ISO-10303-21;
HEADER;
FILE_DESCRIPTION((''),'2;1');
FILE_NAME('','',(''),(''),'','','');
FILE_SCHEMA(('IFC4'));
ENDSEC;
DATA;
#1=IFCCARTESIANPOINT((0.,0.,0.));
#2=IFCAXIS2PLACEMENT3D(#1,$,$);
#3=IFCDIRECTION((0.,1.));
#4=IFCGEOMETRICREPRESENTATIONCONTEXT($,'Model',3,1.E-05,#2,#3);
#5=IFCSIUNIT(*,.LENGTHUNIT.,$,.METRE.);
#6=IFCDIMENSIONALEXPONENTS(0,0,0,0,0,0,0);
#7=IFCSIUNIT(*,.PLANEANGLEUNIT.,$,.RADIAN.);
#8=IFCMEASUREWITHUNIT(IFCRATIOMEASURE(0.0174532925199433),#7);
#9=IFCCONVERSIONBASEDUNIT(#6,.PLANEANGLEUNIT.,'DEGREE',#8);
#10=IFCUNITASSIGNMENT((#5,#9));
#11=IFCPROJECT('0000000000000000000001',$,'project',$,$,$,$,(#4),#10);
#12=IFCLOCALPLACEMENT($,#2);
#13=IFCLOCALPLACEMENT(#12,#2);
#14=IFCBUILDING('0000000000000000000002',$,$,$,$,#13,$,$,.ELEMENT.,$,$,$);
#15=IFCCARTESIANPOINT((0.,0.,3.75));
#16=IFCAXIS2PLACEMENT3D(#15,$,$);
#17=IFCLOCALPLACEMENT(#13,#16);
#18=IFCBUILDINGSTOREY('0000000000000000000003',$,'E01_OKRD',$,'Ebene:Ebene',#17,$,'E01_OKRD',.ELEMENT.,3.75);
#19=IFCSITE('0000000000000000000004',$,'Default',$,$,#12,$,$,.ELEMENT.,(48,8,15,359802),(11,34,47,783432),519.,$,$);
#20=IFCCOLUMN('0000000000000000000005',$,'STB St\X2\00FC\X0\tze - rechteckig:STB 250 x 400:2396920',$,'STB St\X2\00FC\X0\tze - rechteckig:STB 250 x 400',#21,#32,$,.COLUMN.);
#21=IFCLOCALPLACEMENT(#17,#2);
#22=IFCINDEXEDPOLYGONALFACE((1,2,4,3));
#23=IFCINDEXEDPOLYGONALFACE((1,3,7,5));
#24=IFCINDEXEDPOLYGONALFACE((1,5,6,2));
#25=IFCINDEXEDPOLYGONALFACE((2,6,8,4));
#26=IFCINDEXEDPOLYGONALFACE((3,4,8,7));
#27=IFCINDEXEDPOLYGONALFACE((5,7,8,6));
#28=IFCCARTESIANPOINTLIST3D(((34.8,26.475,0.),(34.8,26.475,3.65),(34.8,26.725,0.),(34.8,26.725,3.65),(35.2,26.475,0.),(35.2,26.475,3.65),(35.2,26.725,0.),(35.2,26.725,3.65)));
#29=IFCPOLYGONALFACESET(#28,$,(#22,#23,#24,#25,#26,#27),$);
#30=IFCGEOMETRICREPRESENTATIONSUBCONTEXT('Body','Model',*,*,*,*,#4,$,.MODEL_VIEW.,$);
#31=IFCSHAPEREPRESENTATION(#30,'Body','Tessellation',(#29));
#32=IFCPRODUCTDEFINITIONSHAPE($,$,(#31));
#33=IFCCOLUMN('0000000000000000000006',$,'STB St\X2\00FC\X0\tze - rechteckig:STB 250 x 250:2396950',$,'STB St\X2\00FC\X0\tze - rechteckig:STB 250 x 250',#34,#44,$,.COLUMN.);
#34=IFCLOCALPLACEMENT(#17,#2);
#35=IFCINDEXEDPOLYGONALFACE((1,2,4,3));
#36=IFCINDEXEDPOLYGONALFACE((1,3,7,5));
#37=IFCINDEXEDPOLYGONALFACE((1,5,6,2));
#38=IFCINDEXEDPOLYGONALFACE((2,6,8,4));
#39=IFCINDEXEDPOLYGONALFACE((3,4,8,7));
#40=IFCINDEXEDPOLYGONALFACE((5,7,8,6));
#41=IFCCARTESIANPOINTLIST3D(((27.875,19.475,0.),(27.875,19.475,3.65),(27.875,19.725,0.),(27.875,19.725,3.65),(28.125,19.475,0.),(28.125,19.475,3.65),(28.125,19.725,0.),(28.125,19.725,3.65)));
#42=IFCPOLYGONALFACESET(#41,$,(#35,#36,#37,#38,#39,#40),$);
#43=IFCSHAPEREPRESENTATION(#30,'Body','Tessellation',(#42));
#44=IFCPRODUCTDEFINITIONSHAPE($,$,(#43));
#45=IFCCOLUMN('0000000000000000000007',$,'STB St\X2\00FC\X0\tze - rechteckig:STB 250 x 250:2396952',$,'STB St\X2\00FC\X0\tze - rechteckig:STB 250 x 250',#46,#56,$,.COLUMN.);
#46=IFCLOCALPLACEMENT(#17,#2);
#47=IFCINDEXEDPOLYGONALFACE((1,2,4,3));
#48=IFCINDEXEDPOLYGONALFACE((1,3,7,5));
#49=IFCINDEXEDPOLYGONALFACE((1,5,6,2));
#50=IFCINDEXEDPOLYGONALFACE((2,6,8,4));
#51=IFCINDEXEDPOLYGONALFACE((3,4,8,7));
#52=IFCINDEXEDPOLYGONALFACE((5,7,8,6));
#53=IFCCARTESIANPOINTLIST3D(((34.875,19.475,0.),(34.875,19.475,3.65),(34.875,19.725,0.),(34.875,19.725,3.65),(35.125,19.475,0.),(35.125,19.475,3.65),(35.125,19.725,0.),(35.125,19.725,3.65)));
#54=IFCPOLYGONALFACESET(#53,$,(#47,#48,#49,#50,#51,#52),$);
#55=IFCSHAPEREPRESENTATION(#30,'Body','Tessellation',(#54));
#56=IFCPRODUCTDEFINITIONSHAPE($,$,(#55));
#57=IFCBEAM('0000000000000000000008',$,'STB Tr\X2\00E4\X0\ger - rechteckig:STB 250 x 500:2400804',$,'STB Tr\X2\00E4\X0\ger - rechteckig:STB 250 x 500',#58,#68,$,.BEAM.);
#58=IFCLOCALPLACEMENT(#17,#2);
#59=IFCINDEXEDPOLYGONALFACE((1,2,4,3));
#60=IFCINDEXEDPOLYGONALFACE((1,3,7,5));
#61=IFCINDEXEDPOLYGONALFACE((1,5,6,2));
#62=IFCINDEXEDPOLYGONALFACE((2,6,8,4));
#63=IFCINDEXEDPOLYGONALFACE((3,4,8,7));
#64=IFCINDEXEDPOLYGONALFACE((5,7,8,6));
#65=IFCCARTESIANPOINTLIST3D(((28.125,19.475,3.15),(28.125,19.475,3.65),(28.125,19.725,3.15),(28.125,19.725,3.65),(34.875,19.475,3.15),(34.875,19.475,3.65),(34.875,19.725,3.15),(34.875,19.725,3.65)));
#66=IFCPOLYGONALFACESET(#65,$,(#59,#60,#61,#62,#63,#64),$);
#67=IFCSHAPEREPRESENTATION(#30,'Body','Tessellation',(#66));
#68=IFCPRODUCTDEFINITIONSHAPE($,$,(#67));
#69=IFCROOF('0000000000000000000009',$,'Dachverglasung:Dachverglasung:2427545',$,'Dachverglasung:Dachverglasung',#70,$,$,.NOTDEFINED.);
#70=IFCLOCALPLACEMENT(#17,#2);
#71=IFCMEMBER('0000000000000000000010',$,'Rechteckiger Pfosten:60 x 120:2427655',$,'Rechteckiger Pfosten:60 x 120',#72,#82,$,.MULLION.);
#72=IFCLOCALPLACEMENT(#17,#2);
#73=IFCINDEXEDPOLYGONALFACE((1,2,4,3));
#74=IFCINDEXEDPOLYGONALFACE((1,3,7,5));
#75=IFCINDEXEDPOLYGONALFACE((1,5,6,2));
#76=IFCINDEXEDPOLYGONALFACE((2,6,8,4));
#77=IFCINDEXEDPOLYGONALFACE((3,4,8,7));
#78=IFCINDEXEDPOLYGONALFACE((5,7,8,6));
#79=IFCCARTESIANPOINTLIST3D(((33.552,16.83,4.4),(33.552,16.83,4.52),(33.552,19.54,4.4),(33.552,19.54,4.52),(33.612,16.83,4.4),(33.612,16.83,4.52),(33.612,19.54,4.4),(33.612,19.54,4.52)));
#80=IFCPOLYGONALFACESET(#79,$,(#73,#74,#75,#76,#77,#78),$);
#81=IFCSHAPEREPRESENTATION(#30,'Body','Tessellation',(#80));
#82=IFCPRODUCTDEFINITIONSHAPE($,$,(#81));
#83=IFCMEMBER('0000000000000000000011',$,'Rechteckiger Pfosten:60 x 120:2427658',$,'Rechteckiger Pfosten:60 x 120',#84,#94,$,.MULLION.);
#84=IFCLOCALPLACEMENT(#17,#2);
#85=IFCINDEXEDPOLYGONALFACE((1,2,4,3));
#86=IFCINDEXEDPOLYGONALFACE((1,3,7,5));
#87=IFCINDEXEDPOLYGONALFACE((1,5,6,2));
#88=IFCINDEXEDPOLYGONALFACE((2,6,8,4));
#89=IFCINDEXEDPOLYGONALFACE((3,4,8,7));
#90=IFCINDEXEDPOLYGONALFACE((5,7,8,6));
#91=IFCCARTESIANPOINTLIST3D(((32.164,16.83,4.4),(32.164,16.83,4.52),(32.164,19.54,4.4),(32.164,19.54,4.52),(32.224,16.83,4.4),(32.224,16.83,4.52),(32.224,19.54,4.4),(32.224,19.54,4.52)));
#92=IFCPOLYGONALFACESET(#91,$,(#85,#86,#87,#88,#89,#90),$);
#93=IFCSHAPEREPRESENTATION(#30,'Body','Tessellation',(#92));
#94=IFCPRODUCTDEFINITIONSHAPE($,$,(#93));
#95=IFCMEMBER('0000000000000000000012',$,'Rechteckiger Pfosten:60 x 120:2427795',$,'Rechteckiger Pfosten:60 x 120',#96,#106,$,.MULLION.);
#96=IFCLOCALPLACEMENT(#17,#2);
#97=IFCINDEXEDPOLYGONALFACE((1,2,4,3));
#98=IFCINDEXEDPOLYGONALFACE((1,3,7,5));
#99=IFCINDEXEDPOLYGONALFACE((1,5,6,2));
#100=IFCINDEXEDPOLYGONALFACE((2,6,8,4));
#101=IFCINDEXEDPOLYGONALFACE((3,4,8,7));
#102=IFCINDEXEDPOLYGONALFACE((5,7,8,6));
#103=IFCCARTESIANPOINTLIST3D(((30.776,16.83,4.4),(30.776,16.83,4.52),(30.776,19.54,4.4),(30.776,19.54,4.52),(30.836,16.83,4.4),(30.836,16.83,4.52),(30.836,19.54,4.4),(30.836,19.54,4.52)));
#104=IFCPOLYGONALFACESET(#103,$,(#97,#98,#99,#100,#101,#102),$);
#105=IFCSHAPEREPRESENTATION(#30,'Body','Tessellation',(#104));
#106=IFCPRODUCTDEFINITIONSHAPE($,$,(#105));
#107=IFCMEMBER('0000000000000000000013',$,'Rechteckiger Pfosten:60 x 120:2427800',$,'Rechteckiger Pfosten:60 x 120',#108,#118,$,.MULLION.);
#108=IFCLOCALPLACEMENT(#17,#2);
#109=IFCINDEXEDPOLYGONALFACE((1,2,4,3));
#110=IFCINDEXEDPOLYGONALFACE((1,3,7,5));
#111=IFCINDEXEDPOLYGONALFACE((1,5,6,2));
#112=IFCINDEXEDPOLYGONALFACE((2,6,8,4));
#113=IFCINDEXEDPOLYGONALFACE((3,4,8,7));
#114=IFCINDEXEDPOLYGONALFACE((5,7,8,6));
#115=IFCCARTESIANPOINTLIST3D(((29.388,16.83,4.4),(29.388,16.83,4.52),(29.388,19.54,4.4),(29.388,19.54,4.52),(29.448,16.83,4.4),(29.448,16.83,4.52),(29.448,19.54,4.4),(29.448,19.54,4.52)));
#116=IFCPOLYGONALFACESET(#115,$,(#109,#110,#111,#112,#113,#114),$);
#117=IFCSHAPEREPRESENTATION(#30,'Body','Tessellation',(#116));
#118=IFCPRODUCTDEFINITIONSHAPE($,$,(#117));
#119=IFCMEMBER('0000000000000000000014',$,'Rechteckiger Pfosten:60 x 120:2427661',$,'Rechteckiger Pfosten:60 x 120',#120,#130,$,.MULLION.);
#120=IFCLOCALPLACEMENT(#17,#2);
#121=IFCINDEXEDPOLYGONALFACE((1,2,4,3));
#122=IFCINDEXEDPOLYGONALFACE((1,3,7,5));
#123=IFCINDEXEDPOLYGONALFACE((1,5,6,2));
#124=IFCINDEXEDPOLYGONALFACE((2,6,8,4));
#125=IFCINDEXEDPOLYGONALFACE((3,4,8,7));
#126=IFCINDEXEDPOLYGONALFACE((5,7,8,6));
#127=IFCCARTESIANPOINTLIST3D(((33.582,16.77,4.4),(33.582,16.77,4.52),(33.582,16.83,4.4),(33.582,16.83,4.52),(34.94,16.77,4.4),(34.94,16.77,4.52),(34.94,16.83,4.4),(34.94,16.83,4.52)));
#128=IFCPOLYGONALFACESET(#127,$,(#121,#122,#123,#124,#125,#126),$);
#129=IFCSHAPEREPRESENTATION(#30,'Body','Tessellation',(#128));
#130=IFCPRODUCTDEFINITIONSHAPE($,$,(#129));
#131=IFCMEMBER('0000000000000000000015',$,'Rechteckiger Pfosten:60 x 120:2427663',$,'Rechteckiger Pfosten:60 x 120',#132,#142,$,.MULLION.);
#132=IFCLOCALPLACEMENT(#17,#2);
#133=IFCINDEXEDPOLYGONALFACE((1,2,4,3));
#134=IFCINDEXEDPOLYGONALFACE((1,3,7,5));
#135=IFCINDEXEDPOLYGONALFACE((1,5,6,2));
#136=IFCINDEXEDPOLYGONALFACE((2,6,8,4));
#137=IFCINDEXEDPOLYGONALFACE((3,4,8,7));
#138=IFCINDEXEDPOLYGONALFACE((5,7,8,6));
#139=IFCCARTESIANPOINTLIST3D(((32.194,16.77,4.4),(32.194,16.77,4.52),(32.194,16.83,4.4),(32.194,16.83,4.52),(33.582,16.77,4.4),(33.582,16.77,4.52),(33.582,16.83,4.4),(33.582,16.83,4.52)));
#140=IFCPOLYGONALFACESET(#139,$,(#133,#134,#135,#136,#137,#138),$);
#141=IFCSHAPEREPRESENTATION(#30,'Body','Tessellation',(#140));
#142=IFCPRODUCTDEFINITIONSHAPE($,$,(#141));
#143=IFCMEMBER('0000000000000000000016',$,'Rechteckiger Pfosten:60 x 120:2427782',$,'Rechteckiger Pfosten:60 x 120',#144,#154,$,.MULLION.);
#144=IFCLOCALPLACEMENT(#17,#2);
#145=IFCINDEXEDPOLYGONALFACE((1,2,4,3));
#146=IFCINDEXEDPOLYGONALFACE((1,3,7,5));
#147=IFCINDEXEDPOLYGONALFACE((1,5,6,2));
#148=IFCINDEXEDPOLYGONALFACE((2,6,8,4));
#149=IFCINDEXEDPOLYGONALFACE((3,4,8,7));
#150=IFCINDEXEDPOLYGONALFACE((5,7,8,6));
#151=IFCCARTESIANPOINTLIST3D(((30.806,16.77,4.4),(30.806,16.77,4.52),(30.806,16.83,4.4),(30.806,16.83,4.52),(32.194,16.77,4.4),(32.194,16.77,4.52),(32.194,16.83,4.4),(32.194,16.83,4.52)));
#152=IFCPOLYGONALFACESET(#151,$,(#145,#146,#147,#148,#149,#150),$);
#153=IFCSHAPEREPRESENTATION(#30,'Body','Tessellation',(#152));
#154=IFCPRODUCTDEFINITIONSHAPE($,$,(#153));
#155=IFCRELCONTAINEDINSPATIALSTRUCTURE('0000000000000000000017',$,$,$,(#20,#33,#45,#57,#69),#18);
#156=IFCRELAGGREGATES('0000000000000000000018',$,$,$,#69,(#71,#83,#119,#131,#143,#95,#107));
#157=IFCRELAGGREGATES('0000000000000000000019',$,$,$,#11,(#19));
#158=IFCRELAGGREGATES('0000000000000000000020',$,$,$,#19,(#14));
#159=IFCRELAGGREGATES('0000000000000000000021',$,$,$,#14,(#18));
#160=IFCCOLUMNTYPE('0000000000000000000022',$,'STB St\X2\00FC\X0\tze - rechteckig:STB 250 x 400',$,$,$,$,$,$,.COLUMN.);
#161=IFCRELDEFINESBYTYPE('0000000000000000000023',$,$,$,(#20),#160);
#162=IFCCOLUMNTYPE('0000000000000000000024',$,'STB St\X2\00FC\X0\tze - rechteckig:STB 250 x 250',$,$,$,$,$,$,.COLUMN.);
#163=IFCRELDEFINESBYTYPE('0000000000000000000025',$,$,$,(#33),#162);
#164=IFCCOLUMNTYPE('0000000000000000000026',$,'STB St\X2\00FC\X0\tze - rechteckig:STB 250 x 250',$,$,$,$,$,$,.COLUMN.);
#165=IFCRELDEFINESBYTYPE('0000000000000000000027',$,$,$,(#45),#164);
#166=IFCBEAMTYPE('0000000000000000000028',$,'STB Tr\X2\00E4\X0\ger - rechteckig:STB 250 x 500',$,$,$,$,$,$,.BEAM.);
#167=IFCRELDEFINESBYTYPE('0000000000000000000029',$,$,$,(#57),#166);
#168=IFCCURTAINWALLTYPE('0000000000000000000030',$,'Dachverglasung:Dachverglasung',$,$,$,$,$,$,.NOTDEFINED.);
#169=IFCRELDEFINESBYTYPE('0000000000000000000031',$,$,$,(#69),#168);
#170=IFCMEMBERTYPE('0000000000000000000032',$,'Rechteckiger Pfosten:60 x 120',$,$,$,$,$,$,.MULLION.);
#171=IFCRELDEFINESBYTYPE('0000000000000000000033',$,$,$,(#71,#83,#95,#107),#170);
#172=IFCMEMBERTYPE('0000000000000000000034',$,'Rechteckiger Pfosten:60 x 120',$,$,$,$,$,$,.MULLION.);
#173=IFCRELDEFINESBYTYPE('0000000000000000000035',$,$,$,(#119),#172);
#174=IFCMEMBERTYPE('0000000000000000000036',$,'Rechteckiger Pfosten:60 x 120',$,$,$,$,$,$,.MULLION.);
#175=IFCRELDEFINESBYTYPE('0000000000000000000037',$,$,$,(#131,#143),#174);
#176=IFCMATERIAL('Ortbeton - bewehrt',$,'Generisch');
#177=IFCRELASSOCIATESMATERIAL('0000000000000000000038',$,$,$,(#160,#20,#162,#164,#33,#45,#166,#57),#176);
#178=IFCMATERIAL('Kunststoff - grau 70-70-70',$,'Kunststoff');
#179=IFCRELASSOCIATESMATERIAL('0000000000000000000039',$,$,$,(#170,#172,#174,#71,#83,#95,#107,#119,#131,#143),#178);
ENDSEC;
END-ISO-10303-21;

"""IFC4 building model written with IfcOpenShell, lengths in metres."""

from ifc_helpers import new_model, entity, si_unit, converted_unit, direction, frame, frame_2d, origin, origin_2d_with_axis, place, context, subcontext, project, spatial, rectangle, extrude, source, transform, mapped, material, material_profile, profile_set, profile_usage, type_object, type_shapes, element, aggregate, save


model = new_model("IFC4")

# Units and contexts
model_context = context("Model", 3, precision=1e-05, world=origin(), true_north=direction((0.0, 1.0)))
body_context = subcontext(model_context, "Body", "Model", "MODEL_VIEW")
ifc_project = project(units=[si_unit("LENGTHUNIT", "METRE"), converted_unit("PLANEANGLEUNIT", "DEGREE", entity("IfcRatioMeasure", 0.0174532925199433), si_unit("PLANEANGLEUNIT", "RADIAN"), dimensions=[0, 0, 0, 0, 0, 0, 0])], contexts=[model_context])

# Site, building, storey
site_placement = place(None, frame((0.0, 0.0, 0.0)))
site = spatial("IfcSite", under=ifc_project, at=site_placement, Name="Default", CompositionType="ELEMENT", RefLatitude=(48, 8, 15, 359802), RefLongitude=(11, 34, 47, 783432), RefElevation=519.0)
building_placement = place(site_placement, origin())
building = spatial("IfcBuilding", under=site, at=building_placement, CompositionType="ELEMENT")
storey_placement = place(building_placement, frame((0.0, 0.0, 3.75)))
storey = spatial("IfcBuildingStorey", under=building, at=storey_placement, Name="E01_OKRD", ObjectType="Ebene:Ebene", LongName="E01_OKRD", CompositionType="ELEMENT", Elevation=3.75)

# Columns
ifc_material_1 = material(Name="Ortbeton - bewehrt", Category="Generisch")
ifc_material_profile_1 = material_profile(ifc_material_1, rectangle(XDim=0.4, YDim=0.25, at=frame_2d((0.0, 0.0), x_axis=(1.0, 0.0))), Name="STB 250 x 400")
ifc_profile_set_1 = profile_set([ifc_material_profile_1], Name="STB 250 x 400")
ifc_profile_usage_1 = profile_usage(ifc_profile_set_1)
column_type_1 = type_object("IfcColumnType", Name="STB Stütze - rechteckig:STB 250 x 400", PredefinedType="COLUMN", material=ifc_profile_set_1)
shared_shape_1 = source(origin(), body_context, "Body", "SweptSolid", [
    extrude(rectangle(XDim=0.4, YDim=0.25, at=frame_2d((0.0, 0.0), x_axis=(1.0, 0.0))), frame((0.2, 0.125, 0.0), z_axis=(0.0, 0.0, 1.0), x_axis=(-1.0, 0.0, 0.0)), (0.0, 0.0, 1.0), 3.65),
])
type_shapes(column_type_1, [shared_shape_1])
column_1_placement = place(storey_placement, frame((34.8, 26.475, 0.0)))
element("IfcColumn", 1, at=column_1_placement, inside=storey, type_object=column_type_1, material=ifc_profile_usage_1, Name="STB Stütze - rechteckig:STB 250 x 400:2396920", ObjectType="STB Stütze - rechteckig:STB 250 x 400", PredefinedType="COLUMN", context=body_context, shape_type="MappedRepresentation", body=[
    mapped(shared_shape_1, transform((0.0, 0.0, 0.0), scale=1.0)),
])
ifc_material_profile_2 = material_profile(ifc_material_1, rectangle(XDim=0.25, YDim=0.25, at=origin_2d_with_axis()), Name="STB 250 x 250")
ifc_profile_set_2 = profile_set([ifc_material_profile_2], Name="STB 250 x 250")
ifc_profile_usage_2 = profile_usage(ifc_profile_set_2)
column_type_2 = type_object("IfcColumnType", Name="STB Stütze - rechteckig:STB 250 x 250", PredefinedType="COLUMN", material=ifc_profile_set_2)
shared_shape_2 = source(origin(), body_context, "Body", "SweptSolid", [
    extrude(rectangle(XDim=0.25, YDim=0.25, at=frame_2d((0.0, 0.0), x_axis=(1.0, 0.0))), frame((0.125, 0.125, 0.0), z_axis=(0.0, 0.0, 1.0), x_axis=(-1.0, 0.0, 0.0)), (0.0, 0.0, 1.0), 3.65),
])
type_shapes(column_type_2, [shared_shape_2])
column_2_placement = place(storey_placement, frame((27.875, 19.475, 0.0)))
element("IfcColumn", 2, at=column_2_placement, inside=storey, type_object=column_type_2, material=ifc_profile_usage_2, Name="STB Stütze - rechteckig:STB 250 x 250:2396950", ObjectType="STB Stütze - rechteckig:STB 250 x 250", PredefinedType="COLUMN", context=body_context, shape_type="MappedRepresentation", body=[
    mapped(shared_shape_2, transform((0.0, 0.0, 0.0), scale=1.0)),
])
ifc_profile_usage_3 = profile_usage(ifc_profile_set_2)
column_type_3 = type_object("IfcColumnType", Name="STB Stütze - rechteckig:STB 250 x 250", PredefinedType="COLUMN", material=ifc_profile_set_2)
shared_shape_3 = source(origin(), body_context, "Body", "SweptSolid", [
    extrude(rectangle(XDim=0.25, YDim=0.25, at=frame_2d((0.0, 0.0), x_axis=(1.0, 0.0))), frame((0.125, 0.125, 0.0), z_axis=(0.0, 0.0, 1.0), x_axis=(-1.0, 0.0, 0.0)), (0.0, 0.0, 1.0), 3.65),
])
type_shapes(column_type_3, [shared_shape_3])
column_3_placement = place(storey_placement, frame((34.875, 19.475, 0.0)))
element("IfcColumn", 3, at=column_3_placement, inside=storey, type_object=column_type_3, material=ifc_profile_usage_3, Name="STB Stütze - rechteckig:STB 250 x 250:2396952", ObjectType="STB Stütze - rechteckig:STB 250 x 250", PredefinedType="COLUMN", context=body_context, shape_type="MappedRepresentation", body=[
    mapped(shared_shape_3, transform((0.0, 0.0, 0.0), scale=1.0)),
])

# Beam
ifc_material_profile_3 = material_profile(ifc_material_1, rectangle(XDim=0.5, YDim=0.25, at=frame_2d((0.0, 0.0), x_axis=(1.0, 0.0))), Name="STB 250 x 500")
ifc_profile_set_3 = profile_set([ifc_material_profile_3], Name="STB 250 x 500")
ifc_profile_usage_4 = profile_usage(ifc_profile_set_3, cardinal=8)
beam_type = type_object("IfcBeamType", Name="STB Träger - rechteckig:STB 250 x 500", PredefinedType="BEAM", material=ifc_profile_set_3)
shared_shape_4 = source(origin(), body_context, "Body", "SweptSolid", [
    extrude(rectangle(XDim=0.5, YDim=0.25, at=frame_2d((0.0, 0.0), x_axis=(1.0, 0.0))), frame((0.0, 0.125, 0.25), z_axis=(1.0, 0.0, 0.0), x_axis=(0.0, 0.0, -1.0)), (0.0, 0.0, 1.0), 6.75),
])
type_shapes(beam_type, [shared_shape_4])
beam_placement = place(storey_placement, frame((28.125, 19.475, 3.15)))
element("IfcBeam", 4, at=beam_placement, inside=storey, type_object=beam_type, material=ifc_profile_usage_4, Name="STB Träger - rechteckig:STB 250 x 500:2400804", ObjectType="STB Träger - rechteckig:STB 250 x 500", PredefinedType="BEAM", context=body_context, shape_type="MappedRepresentation", body=[
    mapped(shared_shape_4, transform((0.0, 0.0, 0.0), scale=1.0)),
])

# Roof, members
curtain_wall_type = type_object("IfcCurtainWallType", Name="Dachverglasung:Dachverglasung", PredefinedType="NOTDEFINED")
roof_placement = place(storey_placement, frame((0.0, 0.0, -3.75)))
roof = element("IfcRoof", 5, at=roof_placement, inside=storey, type_object=curtain_wall_type, Name="Dachverglasung:Dachverglasung:2427545", ObjectType="Dachverglasung:Dachverglasung", PredefinedType="NOTDEFINED")
ifc_material_2 = material(Name="Kunststoff - grau 70-70-70", Category="Kunststoff")
ifc_material_profile_4 = material_profile(ifc_material_2, rectangle(XDim=0.06, YDim=0.12, at=frame_2d((0.0, 0.0), x_axis=(1.0, 0.0))), Name="60 x 120")
ifc_profile_set_4 = profile_set([ifc_material_profile_4], Name="60 x 120")
ifc_profile_usage_5 = profile_usage(ifc_profile_set_4)
member_type_1 = type_object("IfcMemberType", Name="Rechteckiger Pfosten:60 x 120", PredefinedType="MULLION", material=ifc_profile_set_4)
shared_shape_5 = source(origin(), body_context, "Body", "SweptSolid", [
    extrude(rectangle(XDim=0.06, YDim=0.12, at=frame_2d((0.0, 0.0), x_axis=(1.0, 0.0))), frame((0.0, 0.0, -2.71), z_axis=(0.0, 0.0, 1.0), x_axis=(-1.0, 0.0, 0.0)), (0.0, 0.0, 1.0), 2.71),
])
type_shapes(member_type_1, [shared_shape_5])
member_1_placement = place(storey_placement, frame((33.582, 16.83, 4.46), z_axis=(0.0, -1.0, 0.0), x_axis=(-1.0, 0.0, 0.0)))
member_1 = element("IfcMember", 6, at=member_1_placement, type_object=member_type_1, material=ifc_profile_usage_5, Name="Rechteckiger Pfosten:60 x 120:2427655", ObjectType="Rechteckiger Pfosten:60 x 120", PredefinedType="MULLION", context=body_context, shape_type="MappedRepresentation", body=[
    mapped(shared_shape_5, transform((0.0, 0.0, 0.0), scale=1.0)),
])
ifc_profile_usage_6 = profile_usage(ifc_profile_set_4)
member_2_placement = place(storey_placement, frame((32.194, 16.83, 4.46), z_axis=(0.0, -1.0, 0.0), x_axis=(-1.0, 0.0, 0.0)))
member_2 = element("IfcMember", 7, at=member_2_placement, type_object=member_type_1, material=ifc_profile_usage_6, Name="Rechteckiger Pfosten:60 x 120:2427658", ObjectType="Rechteckiger Pfosten:60 x 120", PredefinedType="MULLION", context=body_context, shape_type="MappedRepresentation", body=[
    mapped(shared_shape_5, transform((0.0, 0.0, 0.0), scale=1.0)),
])
ifc_profile_usage_7 = profile_usage(ifc_profile_set_4)
member_3_placement = place(storey_placement, frame((30.806, 16.83, 4.46), z_axis=(0.0, -1.0, 0.0), x_axis=(-1.0, 0.0, 0.0)))
member_3 = element("IfcMember", 8, at=member_3_placement, type_object=member_type_1, material=ifc_profile_usage_7, Name="Rechteckiger Pfosten:60 x 120:2427795", ObjectType="Rechteckiger Pfosten:60 x 120", PredefinedType="MULLION", context=body_context, shape_type="MappedRepresentation", body=[
    mapped(shared_shape_5, transform((0.0, 0.0, 0.0), scale=1.0)),
])
ifc_profile_usage_8 = profile_usage(ifc_profile_set_4)
member_4_placement = place(storey_placement, frame((29.418, 16.83, 4.46), z_axis=(0.0, -1.0, 0.0), x_axis=(-1.0, 0.0, 0.0)))
member_4 = element("IfcMember", 9, at=member_4_placement, type_object=member_type_1, material=ifc_profile_usage_8, Name="Rechteckiger Pfosten:60 x 120:2427800", ObjectType="Rechteckiger Pfosten:60 x 120", PredefinedType="MULLION", context=body_context, shape_type="MappedRepresentation", body=[
    mapped(shared_shape_5, transform((0.0, 0.0, 0.0), scale=1.0)),
])
ifc_profile_usage_9 = profile_usage(ifc_profile_set_4)
member_type_2 = type_object("IfcMemberType", Name="Rechteckiger Pfosten:60 x 120", PredefinedType="MULLION", material=ifc_profile_set_4)
shared_shape_6 = source(origin(), body_context, "Body", "SweptSolid", [
    extrude(rectangle(XDim=0.06, YDim=0.12, at=frame_2d((0.0, 0.0), x_axis=(1.0, 0.0))), frame((0.0, 0.0, -1.358), z_axis=(0.0, 0.0, 1.0), x_axis=(-1.0, 0.0, 0.0)), (0.0, 0.0, 1.0), 1.358),
])
type_shapes(member_type_2, [shared_shape_6])
member_5_placement = place(storey_placement, frame((33.582, 16.8, 4.46), z_axis=(-1.0, 0.0, 0.0), x_axis=(0.0, 1.0, 0.0)))
member_5 = element("IfcMember", 10, at=member_5_placement, type_object=member_type_2, material=ifc_profile_usage_9, Name="Rechteckiger Pfosten:60 x 120:2427661", ObjectType="Rechteckiger Pfosten:60 x 120", PredefinedType="MULLION", context=body_context, shape_type="MappedRepresentation", body=[
    mapped(shared_shape_6, transform((0.0, 0.0, 0.0), scale=1.0)),
])
ifc_profile_usage_10 = profile_usage(ifc_profile_set_4)
member_type_3 = type_object("IfcMemberType", Name="Rechteckiger Pfosten:60 x 120", PredefinedType="MULLION", material=ifc_profile_set_4)
shared_shape_7 = source(origin(), body_context, "Body", "SweptSolid", [
    extrude(rectangle(XDim=0.06, YDim=0.12, at=frame_2d((0.0, 0.0), x_axis=(1.0, 0.0))), frame((0.0, 0.0, -1.388), z_axis=(0.0, 0.0, 1.0), x_axis=(-1.0, 0.0, 0.0)), (0.0, 0.0, 1.0), 1.388),
])
type_shapes(member_type_3, [shared_shape_7])
member_6_placement = place(storey_placement, frame((32.194, 16.8, 4.46), z_axis=(-1.0, 0.0, 0.0), x_axis=(0.0, 1.0, 0.0)))
member_6 = element("IfcMember", 11, at=member_6_placement, type_object=member_type_3, material=ifc_profile_usage_10, Name="Rechteckiger Pfosten:60 x 120:2427663", ObjectType="Rechteckiger Pfosten:60 x 120", PredefinedType="MULLION", context=body_context, shape_type="MappedRepresentation", body=[
    mapped(shared_shape_7, transform((0.0, 0.0, 0.0), scale=1.0)),
])
ifc_profile_usage_11 = profile_usage(ifc_profile_set_4)
member_7_placement = place(storey_placement, frame((30.806, 16.8, 4.46), z_axis=(-1.0, 0.0, 0.0), x_axis=(0.0, 1.0, 0.0)))
member_7 = element("IfcMember", 12, at=member_7_placement, type_object=member_type_3, material=ifc_profile_usage_11, Name="Rechteckiger Pfosten:60 x 120:2427782", ObjectType="Rechteckiger Pfosten:60 x 120", PredefinedType="MULLION", context=body_context, shape_type="MappedRepresentation", body=[
    mapped(shared_shape_7, transform((0.0, 0.0, 0.0), scale=1.0)),
])
aggregate(roof, [member_1, member_2, member_5, member_6, member_7, member_3, member_4])

save(model, "model.ifc")
